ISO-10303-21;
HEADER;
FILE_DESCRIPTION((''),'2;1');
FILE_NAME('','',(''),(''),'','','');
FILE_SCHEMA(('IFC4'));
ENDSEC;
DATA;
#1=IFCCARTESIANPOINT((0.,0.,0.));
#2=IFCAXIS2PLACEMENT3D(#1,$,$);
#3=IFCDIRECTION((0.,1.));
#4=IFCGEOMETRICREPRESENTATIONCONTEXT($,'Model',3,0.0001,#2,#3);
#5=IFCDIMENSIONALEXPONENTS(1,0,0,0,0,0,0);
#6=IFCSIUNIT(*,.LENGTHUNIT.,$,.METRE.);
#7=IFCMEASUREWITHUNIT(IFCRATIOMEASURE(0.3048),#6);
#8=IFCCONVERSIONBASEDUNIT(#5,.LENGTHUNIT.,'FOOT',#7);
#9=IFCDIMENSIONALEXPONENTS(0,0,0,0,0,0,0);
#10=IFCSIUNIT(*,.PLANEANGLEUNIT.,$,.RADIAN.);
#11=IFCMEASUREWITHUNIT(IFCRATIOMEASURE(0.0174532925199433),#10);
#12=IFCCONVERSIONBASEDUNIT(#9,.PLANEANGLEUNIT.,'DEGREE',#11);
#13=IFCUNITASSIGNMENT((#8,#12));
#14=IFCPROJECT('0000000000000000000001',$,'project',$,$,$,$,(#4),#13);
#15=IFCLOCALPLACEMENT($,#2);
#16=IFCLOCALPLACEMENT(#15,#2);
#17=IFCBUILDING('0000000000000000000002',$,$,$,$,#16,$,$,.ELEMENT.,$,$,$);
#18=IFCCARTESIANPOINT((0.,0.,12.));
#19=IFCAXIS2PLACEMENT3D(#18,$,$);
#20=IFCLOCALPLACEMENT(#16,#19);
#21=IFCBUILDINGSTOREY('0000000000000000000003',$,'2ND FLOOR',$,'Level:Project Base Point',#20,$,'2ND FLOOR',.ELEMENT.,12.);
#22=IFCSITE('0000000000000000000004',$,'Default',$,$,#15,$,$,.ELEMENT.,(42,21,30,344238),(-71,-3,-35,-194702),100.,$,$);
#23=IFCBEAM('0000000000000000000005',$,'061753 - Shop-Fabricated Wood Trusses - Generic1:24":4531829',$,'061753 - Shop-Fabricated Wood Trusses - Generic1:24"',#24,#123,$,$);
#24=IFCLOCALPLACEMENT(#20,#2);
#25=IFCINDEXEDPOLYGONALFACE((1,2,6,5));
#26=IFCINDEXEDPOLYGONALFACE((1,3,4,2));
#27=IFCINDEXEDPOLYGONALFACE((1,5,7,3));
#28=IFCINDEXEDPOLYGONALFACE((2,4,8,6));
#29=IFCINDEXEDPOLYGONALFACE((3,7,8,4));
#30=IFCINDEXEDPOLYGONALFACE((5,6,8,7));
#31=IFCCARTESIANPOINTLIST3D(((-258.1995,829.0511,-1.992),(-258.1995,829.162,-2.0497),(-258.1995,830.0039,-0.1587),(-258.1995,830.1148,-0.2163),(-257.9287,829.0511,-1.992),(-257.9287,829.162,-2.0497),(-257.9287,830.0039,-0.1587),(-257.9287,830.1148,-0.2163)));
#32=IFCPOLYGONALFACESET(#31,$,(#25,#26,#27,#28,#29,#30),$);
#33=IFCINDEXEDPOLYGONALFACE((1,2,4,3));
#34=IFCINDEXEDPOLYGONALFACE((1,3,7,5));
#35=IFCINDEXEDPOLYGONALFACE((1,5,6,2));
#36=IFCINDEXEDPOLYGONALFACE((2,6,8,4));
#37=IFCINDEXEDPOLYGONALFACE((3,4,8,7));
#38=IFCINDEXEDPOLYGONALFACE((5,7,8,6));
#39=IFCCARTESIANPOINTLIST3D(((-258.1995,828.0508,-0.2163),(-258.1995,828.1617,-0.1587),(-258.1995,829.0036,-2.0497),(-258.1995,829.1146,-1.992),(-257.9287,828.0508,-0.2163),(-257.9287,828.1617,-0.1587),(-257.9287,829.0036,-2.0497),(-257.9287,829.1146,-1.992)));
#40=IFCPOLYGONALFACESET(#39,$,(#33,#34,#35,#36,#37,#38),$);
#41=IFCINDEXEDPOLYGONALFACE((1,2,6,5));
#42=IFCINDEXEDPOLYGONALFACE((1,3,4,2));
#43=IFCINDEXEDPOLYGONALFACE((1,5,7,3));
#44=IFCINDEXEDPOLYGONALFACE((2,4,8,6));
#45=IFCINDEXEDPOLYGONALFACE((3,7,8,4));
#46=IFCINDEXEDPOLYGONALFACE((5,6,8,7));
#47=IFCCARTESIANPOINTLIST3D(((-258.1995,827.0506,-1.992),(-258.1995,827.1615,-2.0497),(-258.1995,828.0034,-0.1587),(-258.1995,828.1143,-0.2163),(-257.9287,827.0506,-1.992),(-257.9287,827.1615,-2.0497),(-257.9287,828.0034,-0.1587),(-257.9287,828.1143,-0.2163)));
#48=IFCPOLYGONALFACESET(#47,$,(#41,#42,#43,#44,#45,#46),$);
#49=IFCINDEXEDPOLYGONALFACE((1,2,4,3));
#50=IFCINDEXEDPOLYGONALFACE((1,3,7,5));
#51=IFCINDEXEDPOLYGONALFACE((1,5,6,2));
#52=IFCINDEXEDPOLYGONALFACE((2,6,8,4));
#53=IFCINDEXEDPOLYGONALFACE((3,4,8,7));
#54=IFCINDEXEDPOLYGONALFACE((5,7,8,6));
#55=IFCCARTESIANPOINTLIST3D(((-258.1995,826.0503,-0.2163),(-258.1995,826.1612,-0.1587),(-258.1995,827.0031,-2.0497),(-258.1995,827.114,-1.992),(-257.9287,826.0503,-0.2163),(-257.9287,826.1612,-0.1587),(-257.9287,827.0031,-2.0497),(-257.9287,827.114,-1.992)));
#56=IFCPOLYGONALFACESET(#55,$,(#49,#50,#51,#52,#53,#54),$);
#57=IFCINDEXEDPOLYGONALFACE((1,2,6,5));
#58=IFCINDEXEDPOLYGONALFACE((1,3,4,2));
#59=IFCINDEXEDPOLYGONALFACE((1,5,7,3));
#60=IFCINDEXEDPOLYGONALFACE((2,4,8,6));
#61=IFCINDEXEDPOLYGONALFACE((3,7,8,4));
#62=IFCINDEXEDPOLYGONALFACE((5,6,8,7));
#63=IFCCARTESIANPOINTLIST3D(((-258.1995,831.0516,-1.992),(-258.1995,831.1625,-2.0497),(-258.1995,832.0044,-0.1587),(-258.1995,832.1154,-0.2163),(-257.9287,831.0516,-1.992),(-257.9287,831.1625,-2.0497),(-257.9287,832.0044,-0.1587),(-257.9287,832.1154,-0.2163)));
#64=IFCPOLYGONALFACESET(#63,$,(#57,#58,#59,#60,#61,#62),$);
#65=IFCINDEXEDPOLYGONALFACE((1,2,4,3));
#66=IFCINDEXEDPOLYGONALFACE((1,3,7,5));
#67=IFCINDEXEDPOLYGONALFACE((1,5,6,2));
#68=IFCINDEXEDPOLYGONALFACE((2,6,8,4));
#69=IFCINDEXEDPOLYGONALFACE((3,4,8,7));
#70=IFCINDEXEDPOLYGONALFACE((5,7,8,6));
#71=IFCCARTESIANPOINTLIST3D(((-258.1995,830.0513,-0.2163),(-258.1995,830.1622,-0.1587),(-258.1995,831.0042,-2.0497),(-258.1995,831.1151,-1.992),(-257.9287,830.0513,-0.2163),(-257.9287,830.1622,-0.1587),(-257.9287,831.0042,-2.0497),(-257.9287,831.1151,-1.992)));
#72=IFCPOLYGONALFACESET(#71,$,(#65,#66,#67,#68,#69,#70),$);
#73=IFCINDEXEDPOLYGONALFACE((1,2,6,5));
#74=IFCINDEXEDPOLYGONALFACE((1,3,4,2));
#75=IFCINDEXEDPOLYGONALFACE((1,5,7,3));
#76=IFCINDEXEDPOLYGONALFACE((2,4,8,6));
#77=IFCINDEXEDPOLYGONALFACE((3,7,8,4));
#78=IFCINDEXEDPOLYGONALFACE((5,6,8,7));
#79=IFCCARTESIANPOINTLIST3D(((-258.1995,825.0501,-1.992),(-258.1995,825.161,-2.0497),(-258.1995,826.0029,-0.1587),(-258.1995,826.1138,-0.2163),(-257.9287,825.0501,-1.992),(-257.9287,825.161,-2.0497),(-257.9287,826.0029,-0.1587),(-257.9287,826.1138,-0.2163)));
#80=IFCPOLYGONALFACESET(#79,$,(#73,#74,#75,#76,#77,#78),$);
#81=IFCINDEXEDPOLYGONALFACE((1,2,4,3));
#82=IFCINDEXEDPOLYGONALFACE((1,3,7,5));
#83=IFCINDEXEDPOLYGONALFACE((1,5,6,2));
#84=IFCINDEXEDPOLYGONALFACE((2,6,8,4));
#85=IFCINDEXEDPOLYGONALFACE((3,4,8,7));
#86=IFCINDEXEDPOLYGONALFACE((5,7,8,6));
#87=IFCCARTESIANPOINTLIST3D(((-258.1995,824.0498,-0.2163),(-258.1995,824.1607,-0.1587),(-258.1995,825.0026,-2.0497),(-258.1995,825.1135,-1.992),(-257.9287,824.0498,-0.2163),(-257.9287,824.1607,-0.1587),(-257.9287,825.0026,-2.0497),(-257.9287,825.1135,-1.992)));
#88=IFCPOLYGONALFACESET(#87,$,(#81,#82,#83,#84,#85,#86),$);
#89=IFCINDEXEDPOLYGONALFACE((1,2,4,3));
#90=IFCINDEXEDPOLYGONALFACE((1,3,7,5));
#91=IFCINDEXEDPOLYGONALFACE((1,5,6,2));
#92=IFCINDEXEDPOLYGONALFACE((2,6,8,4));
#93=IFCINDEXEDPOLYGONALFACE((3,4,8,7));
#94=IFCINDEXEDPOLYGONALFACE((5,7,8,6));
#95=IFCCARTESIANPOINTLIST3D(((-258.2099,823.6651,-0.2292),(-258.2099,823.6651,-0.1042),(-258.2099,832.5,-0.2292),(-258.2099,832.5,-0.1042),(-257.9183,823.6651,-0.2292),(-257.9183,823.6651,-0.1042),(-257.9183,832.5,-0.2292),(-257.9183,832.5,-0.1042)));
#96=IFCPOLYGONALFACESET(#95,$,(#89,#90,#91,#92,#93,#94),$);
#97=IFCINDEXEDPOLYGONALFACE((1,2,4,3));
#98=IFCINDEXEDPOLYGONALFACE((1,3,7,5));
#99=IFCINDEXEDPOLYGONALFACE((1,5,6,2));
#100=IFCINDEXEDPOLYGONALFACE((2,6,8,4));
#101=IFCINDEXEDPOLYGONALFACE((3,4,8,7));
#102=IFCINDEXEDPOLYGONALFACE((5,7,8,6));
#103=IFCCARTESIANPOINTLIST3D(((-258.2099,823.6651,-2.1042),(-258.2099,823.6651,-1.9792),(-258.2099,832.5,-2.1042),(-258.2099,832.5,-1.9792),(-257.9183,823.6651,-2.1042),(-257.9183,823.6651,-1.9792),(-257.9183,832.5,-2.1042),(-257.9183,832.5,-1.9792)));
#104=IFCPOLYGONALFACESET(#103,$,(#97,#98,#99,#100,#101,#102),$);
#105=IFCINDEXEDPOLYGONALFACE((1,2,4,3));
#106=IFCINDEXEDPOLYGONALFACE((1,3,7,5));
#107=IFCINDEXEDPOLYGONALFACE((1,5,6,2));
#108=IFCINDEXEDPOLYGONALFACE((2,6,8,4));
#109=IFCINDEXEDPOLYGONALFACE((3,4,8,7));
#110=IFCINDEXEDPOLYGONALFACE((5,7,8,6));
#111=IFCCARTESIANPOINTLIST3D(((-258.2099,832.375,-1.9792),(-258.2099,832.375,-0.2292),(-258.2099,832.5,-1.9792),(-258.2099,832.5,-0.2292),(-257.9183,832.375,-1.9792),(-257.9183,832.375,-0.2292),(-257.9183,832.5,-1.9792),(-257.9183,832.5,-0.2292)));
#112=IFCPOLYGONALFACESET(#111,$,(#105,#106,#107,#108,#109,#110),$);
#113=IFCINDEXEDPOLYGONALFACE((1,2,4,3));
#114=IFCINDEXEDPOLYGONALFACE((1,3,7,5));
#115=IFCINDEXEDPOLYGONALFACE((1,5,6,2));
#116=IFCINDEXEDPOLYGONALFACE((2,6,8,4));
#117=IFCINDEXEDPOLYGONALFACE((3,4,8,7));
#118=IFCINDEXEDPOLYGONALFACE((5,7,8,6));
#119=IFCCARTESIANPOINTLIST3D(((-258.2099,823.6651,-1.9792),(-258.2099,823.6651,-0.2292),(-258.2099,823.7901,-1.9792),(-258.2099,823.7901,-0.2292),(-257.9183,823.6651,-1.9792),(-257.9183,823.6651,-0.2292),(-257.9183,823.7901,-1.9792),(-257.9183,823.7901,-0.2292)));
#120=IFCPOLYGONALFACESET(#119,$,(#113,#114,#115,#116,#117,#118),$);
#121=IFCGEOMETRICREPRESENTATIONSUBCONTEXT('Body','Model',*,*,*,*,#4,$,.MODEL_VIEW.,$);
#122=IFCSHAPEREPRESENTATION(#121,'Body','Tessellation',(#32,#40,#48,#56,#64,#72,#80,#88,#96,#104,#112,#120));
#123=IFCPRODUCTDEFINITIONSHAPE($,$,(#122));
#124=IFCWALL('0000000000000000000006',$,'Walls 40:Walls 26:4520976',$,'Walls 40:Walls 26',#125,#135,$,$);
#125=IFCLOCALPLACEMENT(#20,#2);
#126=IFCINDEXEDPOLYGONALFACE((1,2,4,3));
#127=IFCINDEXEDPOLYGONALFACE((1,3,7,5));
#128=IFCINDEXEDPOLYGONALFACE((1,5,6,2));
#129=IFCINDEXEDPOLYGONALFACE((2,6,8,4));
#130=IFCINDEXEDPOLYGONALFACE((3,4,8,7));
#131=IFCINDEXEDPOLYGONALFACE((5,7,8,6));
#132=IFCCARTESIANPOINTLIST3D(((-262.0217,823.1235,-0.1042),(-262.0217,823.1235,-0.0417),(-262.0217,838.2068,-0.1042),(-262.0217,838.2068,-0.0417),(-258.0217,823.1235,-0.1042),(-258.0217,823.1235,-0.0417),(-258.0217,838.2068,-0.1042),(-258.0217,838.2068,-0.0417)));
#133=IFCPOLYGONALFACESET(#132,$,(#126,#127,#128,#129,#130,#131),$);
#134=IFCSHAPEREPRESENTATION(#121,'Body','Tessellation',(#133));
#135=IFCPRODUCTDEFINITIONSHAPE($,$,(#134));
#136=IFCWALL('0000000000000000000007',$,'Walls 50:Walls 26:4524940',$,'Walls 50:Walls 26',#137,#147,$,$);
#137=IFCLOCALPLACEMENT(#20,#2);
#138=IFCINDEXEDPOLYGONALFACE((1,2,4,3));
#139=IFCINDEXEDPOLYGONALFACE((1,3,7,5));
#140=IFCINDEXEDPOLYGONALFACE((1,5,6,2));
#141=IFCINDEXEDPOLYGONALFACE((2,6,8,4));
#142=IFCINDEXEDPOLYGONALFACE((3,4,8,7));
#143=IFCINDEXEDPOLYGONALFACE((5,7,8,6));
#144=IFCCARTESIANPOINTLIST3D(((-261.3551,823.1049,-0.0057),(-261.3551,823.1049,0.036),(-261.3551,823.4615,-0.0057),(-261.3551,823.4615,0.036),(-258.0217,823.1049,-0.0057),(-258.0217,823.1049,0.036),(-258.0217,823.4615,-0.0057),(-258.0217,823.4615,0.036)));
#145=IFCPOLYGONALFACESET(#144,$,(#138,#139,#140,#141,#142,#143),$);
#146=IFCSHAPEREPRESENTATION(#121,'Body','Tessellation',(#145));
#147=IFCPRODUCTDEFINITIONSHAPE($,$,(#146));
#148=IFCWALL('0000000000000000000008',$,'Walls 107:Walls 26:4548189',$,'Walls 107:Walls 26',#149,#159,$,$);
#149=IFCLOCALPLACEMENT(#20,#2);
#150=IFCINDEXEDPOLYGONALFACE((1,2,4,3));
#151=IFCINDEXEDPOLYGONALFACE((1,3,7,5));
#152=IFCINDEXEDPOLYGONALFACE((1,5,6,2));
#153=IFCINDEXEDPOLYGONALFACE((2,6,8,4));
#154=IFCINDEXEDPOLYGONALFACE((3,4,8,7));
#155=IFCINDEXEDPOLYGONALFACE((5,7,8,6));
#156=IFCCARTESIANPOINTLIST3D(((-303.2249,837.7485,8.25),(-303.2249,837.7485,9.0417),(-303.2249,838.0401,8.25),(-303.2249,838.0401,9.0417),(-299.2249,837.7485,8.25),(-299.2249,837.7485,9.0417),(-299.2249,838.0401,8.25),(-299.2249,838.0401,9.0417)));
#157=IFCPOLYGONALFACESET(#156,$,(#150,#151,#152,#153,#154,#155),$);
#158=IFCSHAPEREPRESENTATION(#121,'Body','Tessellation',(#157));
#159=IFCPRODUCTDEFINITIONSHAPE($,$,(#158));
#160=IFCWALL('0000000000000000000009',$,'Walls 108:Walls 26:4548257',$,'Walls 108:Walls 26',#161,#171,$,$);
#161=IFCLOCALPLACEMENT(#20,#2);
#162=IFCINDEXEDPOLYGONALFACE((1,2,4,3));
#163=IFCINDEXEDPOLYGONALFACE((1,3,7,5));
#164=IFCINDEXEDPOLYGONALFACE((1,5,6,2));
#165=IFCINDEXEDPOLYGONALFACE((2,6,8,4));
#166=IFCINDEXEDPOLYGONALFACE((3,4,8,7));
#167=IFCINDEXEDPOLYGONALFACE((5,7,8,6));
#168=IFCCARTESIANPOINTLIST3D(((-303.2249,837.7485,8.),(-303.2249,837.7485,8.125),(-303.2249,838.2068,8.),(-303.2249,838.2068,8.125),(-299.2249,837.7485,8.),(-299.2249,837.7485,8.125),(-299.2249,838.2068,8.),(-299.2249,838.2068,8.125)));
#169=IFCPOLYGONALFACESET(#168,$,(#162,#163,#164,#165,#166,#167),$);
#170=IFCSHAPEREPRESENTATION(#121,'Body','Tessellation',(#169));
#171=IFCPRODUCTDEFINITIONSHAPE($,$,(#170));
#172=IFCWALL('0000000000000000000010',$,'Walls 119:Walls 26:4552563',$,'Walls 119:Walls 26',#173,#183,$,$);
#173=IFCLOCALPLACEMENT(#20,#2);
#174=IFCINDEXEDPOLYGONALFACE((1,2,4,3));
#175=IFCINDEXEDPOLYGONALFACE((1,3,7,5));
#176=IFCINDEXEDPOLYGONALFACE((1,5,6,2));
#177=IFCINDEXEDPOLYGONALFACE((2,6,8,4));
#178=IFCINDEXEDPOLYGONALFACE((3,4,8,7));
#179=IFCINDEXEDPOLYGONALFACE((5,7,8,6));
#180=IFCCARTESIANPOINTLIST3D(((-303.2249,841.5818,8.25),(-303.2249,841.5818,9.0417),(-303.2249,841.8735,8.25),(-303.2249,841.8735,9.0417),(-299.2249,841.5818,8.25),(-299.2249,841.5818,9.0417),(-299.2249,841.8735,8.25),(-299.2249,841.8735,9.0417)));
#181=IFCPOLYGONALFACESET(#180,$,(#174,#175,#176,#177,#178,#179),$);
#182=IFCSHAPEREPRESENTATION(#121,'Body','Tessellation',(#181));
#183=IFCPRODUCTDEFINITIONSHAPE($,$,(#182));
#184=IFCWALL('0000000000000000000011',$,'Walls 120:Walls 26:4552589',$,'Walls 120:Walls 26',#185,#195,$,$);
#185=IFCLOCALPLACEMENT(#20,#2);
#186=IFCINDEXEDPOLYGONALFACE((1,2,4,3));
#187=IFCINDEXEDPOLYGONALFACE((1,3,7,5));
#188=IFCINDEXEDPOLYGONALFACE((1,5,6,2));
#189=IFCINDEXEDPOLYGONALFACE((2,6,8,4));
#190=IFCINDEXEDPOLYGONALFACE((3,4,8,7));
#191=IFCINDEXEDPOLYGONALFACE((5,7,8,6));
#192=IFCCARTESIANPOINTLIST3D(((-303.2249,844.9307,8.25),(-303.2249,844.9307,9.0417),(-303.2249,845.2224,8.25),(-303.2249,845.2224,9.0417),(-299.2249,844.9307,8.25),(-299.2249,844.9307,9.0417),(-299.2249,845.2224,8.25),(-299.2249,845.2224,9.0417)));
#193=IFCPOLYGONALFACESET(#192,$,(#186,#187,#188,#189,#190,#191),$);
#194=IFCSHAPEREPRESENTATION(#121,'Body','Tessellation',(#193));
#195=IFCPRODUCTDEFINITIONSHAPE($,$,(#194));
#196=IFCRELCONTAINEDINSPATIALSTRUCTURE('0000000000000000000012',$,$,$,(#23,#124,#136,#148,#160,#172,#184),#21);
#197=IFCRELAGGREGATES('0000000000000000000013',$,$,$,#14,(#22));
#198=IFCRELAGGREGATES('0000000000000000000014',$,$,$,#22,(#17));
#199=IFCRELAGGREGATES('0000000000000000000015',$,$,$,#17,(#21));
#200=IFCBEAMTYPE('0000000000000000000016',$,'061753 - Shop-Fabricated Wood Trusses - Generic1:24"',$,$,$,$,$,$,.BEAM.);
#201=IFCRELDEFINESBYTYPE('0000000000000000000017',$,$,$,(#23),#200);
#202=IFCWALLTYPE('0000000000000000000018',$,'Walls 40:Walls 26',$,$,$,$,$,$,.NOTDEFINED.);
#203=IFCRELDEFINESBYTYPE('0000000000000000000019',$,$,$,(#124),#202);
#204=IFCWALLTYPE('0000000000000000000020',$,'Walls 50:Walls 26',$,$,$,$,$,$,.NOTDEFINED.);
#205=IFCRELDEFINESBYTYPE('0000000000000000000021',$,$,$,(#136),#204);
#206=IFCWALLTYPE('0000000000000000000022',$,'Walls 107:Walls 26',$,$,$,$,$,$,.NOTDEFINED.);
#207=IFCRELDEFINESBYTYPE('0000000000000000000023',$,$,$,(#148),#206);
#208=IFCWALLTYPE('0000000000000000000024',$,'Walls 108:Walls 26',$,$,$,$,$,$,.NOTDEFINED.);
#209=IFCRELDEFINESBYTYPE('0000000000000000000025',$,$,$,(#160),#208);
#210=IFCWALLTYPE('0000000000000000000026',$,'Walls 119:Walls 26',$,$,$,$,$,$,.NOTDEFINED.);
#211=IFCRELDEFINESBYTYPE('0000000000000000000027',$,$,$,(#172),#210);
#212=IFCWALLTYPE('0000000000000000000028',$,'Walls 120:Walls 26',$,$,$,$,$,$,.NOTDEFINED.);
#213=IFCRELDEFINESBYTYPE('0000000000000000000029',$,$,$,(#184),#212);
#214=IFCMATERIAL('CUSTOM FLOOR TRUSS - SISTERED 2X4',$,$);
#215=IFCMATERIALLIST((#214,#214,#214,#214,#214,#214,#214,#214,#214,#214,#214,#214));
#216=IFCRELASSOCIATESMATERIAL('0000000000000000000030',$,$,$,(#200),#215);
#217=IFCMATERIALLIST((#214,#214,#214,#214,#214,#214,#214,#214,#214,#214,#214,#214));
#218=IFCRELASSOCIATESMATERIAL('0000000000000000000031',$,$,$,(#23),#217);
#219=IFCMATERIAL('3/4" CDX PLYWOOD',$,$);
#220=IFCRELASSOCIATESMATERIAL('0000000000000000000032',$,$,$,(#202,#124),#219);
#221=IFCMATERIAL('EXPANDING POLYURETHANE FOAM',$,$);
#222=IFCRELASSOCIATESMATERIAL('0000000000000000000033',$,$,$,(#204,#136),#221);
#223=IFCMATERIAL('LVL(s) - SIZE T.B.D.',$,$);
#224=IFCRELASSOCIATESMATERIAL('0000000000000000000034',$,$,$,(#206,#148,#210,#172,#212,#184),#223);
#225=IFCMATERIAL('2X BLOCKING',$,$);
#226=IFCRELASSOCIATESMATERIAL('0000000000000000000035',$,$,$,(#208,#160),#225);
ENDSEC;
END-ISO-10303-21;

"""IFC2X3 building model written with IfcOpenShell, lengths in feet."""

from ifc_helpers import new_model, entity, si_unit, converted_unit, direction, frame, frame_2d, origin, origin_2d_with_axis, place, context, subcontext, project, spatial, rectangle, extrude, source, transform, mapped, material, material_list, type_object, type_shapes, element, save


model = new_model("IFC2X3")

# Units and contexts
model_context = context("Model", 3, precision=0.0001, world=origin(), true_north=direction((0.0, 1.0)))
body_context = subcontext(model_context, "Body", "Model", "MODEL_VIEW")
ifc_project = project(units=[converted_unit("LENGTHUNIT", "FOOT", entity("IfcRatioMeasure", 0.3048), si_unit("LENGTHUNIT", "METRE"), dimensions=[1, 0, 0, 0, 0, 0, 0]), converted_unit("PLANEANGLEUNIT", "DEGREE", entity("IfcRatioMeasure", 0.0174532925199433), si_unit("PLANEANGLEUNIT", "RADIAN"), dimensions=[0, 0, 0, 0, 0, 0, 0])], contexts=[model_context])

# Site, building, storey
site_placement = place(None, origin())
site = spatial("IfcSite", under=ifc_project, at=site_placement, Name="Default", CompositionType="ELEMENT", RefLatitude=(42, 21, 30, 344238), RefLongitude=(-71, -3, -35, -194702), RefElevation=100.0)
building_placement = place(site_placement, origin())
building = spatial("IfcBuilding", under=site, at=building_placement, CompositionType="ELEMENT")
storey_placement = place(building_placement, frame((0.0, 0.0, 12.0)))
storey = spatial("IfcBuildingStorey", under=building, at=storey_placement, Name="2ND FLOOR", ObjectType="Level:Project Base Point", LongName="2ND FLOOR", CompositionType="ELEMENT", Elevation=12.0)

# Beam
ifc_material_1 = material(Name="CUSTOM FLOOR TRUSS - SISTERED 2X4")
ifc_material_list_1 = material_list([ifc_material_1, ifc_material_1, ifc_material_1, ifc_material_1, ifc_material_1, ifc_material_1, ifc_material_1, ifc_material_1, ifc_material_1, ifc_material_1, ifc_material_1, ifc_material_1])
ifc_material_list_2 = material_list([ifc_material_1, ifc_material_1, ifc_material_1, ifc_material_1, ifc_material_1, ifc_material_1, ifc_material_1, ifc_material_1, ifc_material_1, ifc_material_1, ifc_material_1, ifc_material_1])
beam_type = type_object("IfcBeamType", Name="061753 - Shop-Fabricated Wood Trusses - Generic1:24\"", PredefinedType="BEAM", material=ifc_material_list_2)
shared_shape_1 = source(origin(), body_context, "Body", "SweptSolid", [
    extrude(rectangle(XDim=2.0662, YDim=0.125, at=frame_2d((0.0, 0.0), x_axis=(1.0, 0.0))), frame((1.5004, -0.1354, 0.0), z_axis=(0.0, 1.0, 0.0), x_axis=(0.461164, 0.0, 0.887315)), (0.0, 0.0, 1.0), 0.2708),
    extrude(rectangle(XDim=2.0662, YDim=0.125, at=origin_2d_with_axis()), frame((0.5001, -0.1354, 0.0), z_axis=(0.0, 1.0, 0.0), x_axis=(0.461164, 0.0, -0.887315)), (0.0, 0.0, 1.0), 0.2708),
    extrude(rectangle(XDim=2.0662, YDim=0.125, at=origin_2d_with_axis()), frame((-0.5001, -0.1354, 0.0), z_axis=(0.0, 1.0, 0.0), x_axis=(0.461164, 0.0, 0.887315)), (0.0, 0.0, 1.0), 0.2708),
    extrude(rectangle(XDim=2.0662, YDim=0.125, at=frame_2d((0.0, 0.0), x_axis=(1.0, 0.0))), frame((-1.5004, -0.1354, 0.0), z_axis=(0.0, 1.0, 0.0), x_axis=(0.461164, 0.0, -0.887315)), (0.0, 0.0, 1.0), 0.2708),
    extrude(rectangle(XDim=2.0662, YDim=0.125, at=frame_2d((0.0, 0.0), x_axis=(1.0, 0.0))), frame((3.5009, -0.1354, 0.0), z_axis=(0.0, 1.0, 0.0), x_axis=(0.461164, 0.0, 0.887315)), (0.0, 0.0, 1.0), 0.2708),
    extrude(rectangle(XDim=2.0662, YDim=0.125, at=origin_2d_with_axis()), frame((2.5006, -0.1354, 0.0), z_axis=(0.0, 1.0, 0.0), x_axis=(0.461164, 0.0, -0.887315)), (0.0, 0.0, 1.0), 0.2708),
    extrude(rectangle(XDim=2.0662, YDim=0.125, at=origin_2d_with_axis()), frame((-2.5006, -0.1354, 0.0), z_axis=(0.0, 1.0, 0.0), x_axis=(0.461164, 0.0, 0.887315)), (0.0, 0.0, 1.0), 0.2708),
    extrude(rectangle(XDim=2.0662, YDim=0.125, at=frame_2d((0.0, 0.0), x_axis=(1.0, 0.0))), frame((-3.5009, -0.1354, 0.0), z_axis=(0.0, 1.0, 0.0), x_axis=(0.461164, 0.0, -0.887315)), (0.0, 0.0, 1.0), 0.2708),
    extrude(rectangle(XDim=0.125, YDim=0.2917, at=origin_2d_with_axis()), frame((-4.4174, 0.0, 0.9375), z_axis=(1.0, 0.0, 0.0), x_axis=(0.0, 0.0, -1.0)), (0.0, 0.0, 1.0), 8.8349),
    extrude(rectangle(XDim=0.125, YDim=0.2917, at=origin_2d_with_axis()), frame((-4.4174, 0.0, -0.9375), z_axis=(1.0, 0.0, 0.0), x_axis=(0.0, 0.0, -1.0)), (0.0, 0.0, 1.0), 8.8349),
    extrude(rectangle(XDim=1.75, YDim=0.2917, at=origin_2d_with_axis()), frame((4.2924, 0.0, 0.0), z_axis=(1.0, 0.0, 0.0), x_axis=(0.0, 0.0, -1.0)), (0.0, 0.0, 1.0), 0.125),
    extrude(rectangle(XDim=1.75, YDim=0.2917, at=origin_2d_with_axis()), frame((-4.4174, 0.0, 0.0), z_axis=(1.0, 0.0, 0.0), x_axis=(0.0, 0.0, -1.0)), (0.0, 0.0, 1.0), 0.125),
])
type_shapes(beam_type, [shared_shape_1])
beam_placement = place(storey_placement, frame((-258.0641, 828.0826, -1.1042), z_axis=(0.0, 0.0, 1.0), x_axis=(0.0, 1.0, 0.0)))
element("IfcBeam", 1, at=beam_placement, inside=storey, type_object=beam_type, material=ifc_material_list_1, Name="061753 - Shop-Fabricated Wood Trusses - Generic1:24\":4531829", ObjectType="061753 - Shop-Fabricated Wood Trusses - Generic1:24\"", context=body_context, shape_type="MappedRepresentation", body=[
    mapped(shared_shape_1, transform((0.0, 0.0, 0.0), scale=1.0)),
])

# Walls
ifc_material_2 = material(Name="3/4\" CDX PLYWOOD")
wall_type_1 = type_object("IfcWallType", Name="Walls 40:Walls 26", PredefinedType="NOTDEFINED", material=ifc_material_2)
wall_1_placement = place(storey_placement, frame((-262.0217, 823.1235, -0.1042), z_axis=(0.0, 0.0, 1.0), x_axis=(0.0, 1.0, 0.0)))
element("IfcWall", 2, at=wall_1_placement, inside=storey, type_object=wall_type_1, material=ifc_material_2, Name="Walls 40:Walls 26:4520976", ObjectType="Walls 40:Walls 26", context=body_context, shape_type="SweptSolid", body=[
    extrude(rectangle(XDim=4.0, YDim=15.0833, at=origin_2d_with_axis()), frame((7.5417, -2.0, 0.0), z_axis=(0.0, 0.0, 1.0), x_axis=(0.0, 1.0, 0.0)), (0.0, 0.0, 1.0), 0.0625),
])
ifc_material_3 = material(Name="EXPANDING POLYURETHANE FOAM")
wall_type_2 = type_object("IfcWallType", Name="Walls 50:Walls 26", PredefinedType="NOTDEFINED", material=ifc_material_3)
wall_2_placement = place(storey_placement, frame((-261.3551, 823.1049, -0.0057)))
element("IfcWall", 3, at=wall_2_placement, inside=storey, type_object=wall_type_2, material=ifc_material_3, Name="Walls 50:Walls 26:4524940", ObjectType="Walls 50:Walls 26", context=body_context, shape_type="SweptSolid", body=[
    extrude(rectangle(XDim=3.3333, YDim=0.3565, at=frame_2d((0.0, 0.0), x_axis=(1.0, 0.0))), frame((1.6667, 0.1783, 0.0), z_axis=(0.0, 0.0, 1.0), x_axis=(-1.0, 0.0, 0.0)), (0.0, 0.0, 1.0), 0.0417),
])
ifc_material_4 = material(Name="LVL(s) - SIZE T.B.D.")
wall_type_3 = type_object("IfcWallType", Name="Walls 107:Walls 26", PredefinedType="NOTDEFINED", material=ifc_material_4)
wall_3_placement = place(storey_placement, frame((-303.2249, 837.7485, 8.25)))
element("IfcWall", 4, at=wall_3_placement, inside=storey, type_object=wall_type_3, material=ifc_material_4, Name="Walls 107:Walls 26:4548189", ObjectType="Walls 107:Walls 26", context=body_context, shape_type="SweptSolid", body=[
    extrude(rectangle(XDim=4.0, YDim=0.2917, at=frame_2d((0.0, 0.0), x_axis=(1.0, 0.0))), frame((2.0, 0.1458, 0.0), z_axis=(0.0, 0.0, 1.0), x_axis=(-1.0, 0.0, 0.0)), (0.0, 0.0, 1.0), 0.7917),
])
ifc_material_5 = material(Name="2X BLOCKING")
wall_type_4 = type_object("IfcWallType", Name="Walls 108:Walls 26", PredefinedType="NOTDEFINED", material=ifc_material_5)
wall_4_placement = place(storey_placement, frame((-303.2249, 837.7485, 8.0)))
element("IfcWall", 5, at=wall_4_placement, inside=storey, type_object=wall_type_4, material=ifc_material_5, Name="Walls 108:Walls 26:4548257", ObjectType="Walls 108:Walls 26", context=body_context, shape_type="SweptSolid", body=[
    extrude(rectangle(XDim=4.0, YDim=0.4583, at=origin_2d_with_axis()), frame((2.0, 0.2292, 0.0), z_axis=(0.0, 0.0, 1.0), x_axis=(-1.0, 0.0, 0.0)), (0.0, 0.0, 1.0), 0.125),
])
wall_type_5 = type_object("IfcWallType", Name="Walls 119:Walls 26", PredefinedType="NOTDEFINED", material=ifc_material_4)
wall_5_placement = place(storey_placement, frame((-303.2249, 841.5818, 8.25)))
element("IfcWall", 6, at=wall_5_placement, inside=storey, type_object=wall_type_5, material=ifc_material_4, Name="Walls 119:Walls 26:4552563", ObjectType="Walls 119:Walls 26", context=body_context, shape_type="SweptSolid", body=[
    extrude(rectangle(XDim=4.0, YDim=0.2917, at=frame_2d((0.0, 0.0), x_axis=(1.0, 0.0))), frame((2.0, 0.1458, 0.0), z_axis=(0.0, 0.0, 1.0), x_axis=(-1.0, 0.0, 0.0)), (0.0, 0.0, 1.0), 0.7917),
])
wall_type_6 = type_object("IfcWallType", Name="Walls 120:Walls 26", PredefinedType="NOTDEFINED", material=ifc_material_4)
wall_6_placement = place(storey_placement, frame((-303.2249, 844.9307, 8.25)))
element("IfcWall", 7, at=wall_6_placement, inside=storey, type_object=wall_type_6, material=ifc_material_4, Name="Walls 120:Walls 26:4552589", ObjectType="Walls 120:Walls 26", context=body_context, shape_type="SweptSolid", body=[
    extrude(rectangle(XDim=4.0, YDim=0.2917, at=frame_2d((0.0, 0.0), x_axis=(1.0, 0.0))), frame((2.0, 0.1458, 0.0), z_axis=(0.0, 0.0, 1.0), x_axis=(-1.0, 0.0, 0.0)), (0.0, 0.0, 1.0), 0.7917),
])

save(model, "model.ifc")
